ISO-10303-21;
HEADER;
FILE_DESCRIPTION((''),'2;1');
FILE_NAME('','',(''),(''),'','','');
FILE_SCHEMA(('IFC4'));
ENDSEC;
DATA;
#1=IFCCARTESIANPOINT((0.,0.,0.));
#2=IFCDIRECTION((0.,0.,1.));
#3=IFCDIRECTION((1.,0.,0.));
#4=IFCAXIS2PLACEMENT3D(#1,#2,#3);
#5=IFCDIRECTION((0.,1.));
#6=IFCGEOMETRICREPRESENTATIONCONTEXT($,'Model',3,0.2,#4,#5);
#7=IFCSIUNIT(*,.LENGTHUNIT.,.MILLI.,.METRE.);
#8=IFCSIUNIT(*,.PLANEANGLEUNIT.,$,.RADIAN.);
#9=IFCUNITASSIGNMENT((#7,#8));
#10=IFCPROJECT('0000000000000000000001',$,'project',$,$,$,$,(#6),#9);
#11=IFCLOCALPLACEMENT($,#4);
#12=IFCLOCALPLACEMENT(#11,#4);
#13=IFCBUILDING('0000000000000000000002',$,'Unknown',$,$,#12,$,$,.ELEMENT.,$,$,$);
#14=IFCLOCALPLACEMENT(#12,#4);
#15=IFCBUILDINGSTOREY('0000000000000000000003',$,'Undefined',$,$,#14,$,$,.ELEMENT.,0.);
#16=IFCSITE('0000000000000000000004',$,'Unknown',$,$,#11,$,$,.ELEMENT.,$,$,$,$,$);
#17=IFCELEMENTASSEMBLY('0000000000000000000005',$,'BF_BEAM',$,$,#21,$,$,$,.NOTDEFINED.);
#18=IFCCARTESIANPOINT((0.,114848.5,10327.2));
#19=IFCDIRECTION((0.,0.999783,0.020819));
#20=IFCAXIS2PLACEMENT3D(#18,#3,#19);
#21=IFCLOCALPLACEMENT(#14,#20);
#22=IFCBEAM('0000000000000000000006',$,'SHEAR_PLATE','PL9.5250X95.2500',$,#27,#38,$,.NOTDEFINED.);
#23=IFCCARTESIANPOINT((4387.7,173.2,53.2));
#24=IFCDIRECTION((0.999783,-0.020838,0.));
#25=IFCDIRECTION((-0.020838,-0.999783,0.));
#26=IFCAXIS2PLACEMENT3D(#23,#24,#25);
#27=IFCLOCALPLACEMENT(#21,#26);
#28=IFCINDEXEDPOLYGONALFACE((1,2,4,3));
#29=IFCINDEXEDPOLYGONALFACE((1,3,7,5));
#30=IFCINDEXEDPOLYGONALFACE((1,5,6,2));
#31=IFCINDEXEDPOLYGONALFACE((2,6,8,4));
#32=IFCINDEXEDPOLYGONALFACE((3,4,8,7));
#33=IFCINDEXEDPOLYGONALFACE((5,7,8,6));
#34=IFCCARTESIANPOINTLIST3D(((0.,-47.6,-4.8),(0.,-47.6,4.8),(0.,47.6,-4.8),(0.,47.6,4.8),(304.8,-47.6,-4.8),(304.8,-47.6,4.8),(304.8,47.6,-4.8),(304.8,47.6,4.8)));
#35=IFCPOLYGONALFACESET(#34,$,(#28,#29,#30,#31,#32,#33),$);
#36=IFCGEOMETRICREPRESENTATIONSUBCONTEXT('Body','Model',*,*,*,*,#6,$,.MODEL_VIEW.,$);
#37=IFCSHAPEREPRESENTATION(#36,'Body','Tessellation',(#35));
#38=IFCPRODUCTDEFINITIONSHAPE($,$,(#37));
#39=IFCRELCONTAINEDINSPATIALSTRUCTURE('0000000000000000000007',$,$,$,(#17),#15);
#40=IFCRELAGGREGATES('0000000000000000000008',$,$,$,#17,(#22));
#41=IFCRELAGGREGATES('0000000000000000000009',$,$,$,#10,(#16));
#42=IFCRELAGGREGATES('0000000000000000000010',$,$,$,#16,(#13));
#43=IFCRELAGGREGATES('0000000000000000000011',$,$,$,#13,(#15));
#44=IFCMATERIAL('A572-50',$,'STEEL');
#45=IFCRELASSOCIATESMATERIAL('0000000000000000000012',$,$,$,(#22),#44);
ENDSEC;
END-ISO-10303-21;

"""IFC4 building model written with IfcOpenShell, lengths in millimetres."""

from ifc_helpers import new_model, si_unit, direction, frame, origin_with_axes, place, context, subcontext, project, spatial, line, indexed_curve, outline, extrude, material, element, aggregate, save


model = new_model("IFC4")

# Units and contexts
model_context = context("Model", 3, precision=0.2, world=origin_with_axes(), true_north=direction((0.0, 1.0)))
body_context = subcontext(model_context, "Body", "Model", "MODEL_VIEW")
ifc_project = project(units=[si_unit("LENGTHUNIT", "METRE", prefix="MILLI"), si_unit("PLANEANGLEUNIT", "RADIAN")], contexts=[model_context])

# Site, building, storey
site_placement = place(None, origin_with_axes())
site = spatial("IfcSite", under=ifc_project, at=site_placement, Name="Unknown", CompositionType="ELEMENT")
building_placement = place(site_placement, origin_with_axes())
building = spatial("IfcBuilding", under=site, at=building_placement, Name="Unknown", CompositionType="ELEMENT")
storey_placement = place(building_placement, origin_with_axes())
storey = spatial("IfcBuildingStorey", under=building, at=storey_placement, Name="Undefined", CompositionType="ELEMENT", Elevation=0.0)

# Element assembly, beam
assembly_1_placement = place(storey_placement, frame((0.0, 114848.5, 10327.2), z_axis=(1.0, 0.0, 0.0), x_axis=(0.0, 0.999783, 0.020819)))
assembly_1 = element("IfcElementAssembly", 1, at=assembly_1_placement, inside=storey, Name="BF_BEAM", PredefinedType="NOTDEFINED")
ifc_material_1 = material(Name="A572-50", Category="STEEL")
beam_1_placement = place(assembly_1_placement, frame((4387.7, 173.2, 53.2), z_axis=(0.999783, -0.020838, 0.0), x_axis=(-0.020838, -0.999783, 0.0)))
beam_1 = element("IfcBeam", 2, at=beam_1_placement, material=ifc_material_1, Name="SHEAR_PLATE", Description="PL9.5250X95.2500", PredefinedType="NOTDEFINED", context=body_context, shape_type="SolidModel", body=[
    extrude(outline(indexed_curve([(-4.8, -47.6), (4.8, -47.6), (4.8, 47.6), (-4.8, 47.6)], segments=[line(1, 2, 3, 4, 1)])), frame((0.0, 0.0, 0.0), z_axis=(-1.0, 0.0, 0.0), x_axis=(0.0, 0.0, 1.0)), (0.0, 0.0, -1.0), 304.8),
])
aggregate(assembly_1, [beam_1])

save(model, "model.ifc")
